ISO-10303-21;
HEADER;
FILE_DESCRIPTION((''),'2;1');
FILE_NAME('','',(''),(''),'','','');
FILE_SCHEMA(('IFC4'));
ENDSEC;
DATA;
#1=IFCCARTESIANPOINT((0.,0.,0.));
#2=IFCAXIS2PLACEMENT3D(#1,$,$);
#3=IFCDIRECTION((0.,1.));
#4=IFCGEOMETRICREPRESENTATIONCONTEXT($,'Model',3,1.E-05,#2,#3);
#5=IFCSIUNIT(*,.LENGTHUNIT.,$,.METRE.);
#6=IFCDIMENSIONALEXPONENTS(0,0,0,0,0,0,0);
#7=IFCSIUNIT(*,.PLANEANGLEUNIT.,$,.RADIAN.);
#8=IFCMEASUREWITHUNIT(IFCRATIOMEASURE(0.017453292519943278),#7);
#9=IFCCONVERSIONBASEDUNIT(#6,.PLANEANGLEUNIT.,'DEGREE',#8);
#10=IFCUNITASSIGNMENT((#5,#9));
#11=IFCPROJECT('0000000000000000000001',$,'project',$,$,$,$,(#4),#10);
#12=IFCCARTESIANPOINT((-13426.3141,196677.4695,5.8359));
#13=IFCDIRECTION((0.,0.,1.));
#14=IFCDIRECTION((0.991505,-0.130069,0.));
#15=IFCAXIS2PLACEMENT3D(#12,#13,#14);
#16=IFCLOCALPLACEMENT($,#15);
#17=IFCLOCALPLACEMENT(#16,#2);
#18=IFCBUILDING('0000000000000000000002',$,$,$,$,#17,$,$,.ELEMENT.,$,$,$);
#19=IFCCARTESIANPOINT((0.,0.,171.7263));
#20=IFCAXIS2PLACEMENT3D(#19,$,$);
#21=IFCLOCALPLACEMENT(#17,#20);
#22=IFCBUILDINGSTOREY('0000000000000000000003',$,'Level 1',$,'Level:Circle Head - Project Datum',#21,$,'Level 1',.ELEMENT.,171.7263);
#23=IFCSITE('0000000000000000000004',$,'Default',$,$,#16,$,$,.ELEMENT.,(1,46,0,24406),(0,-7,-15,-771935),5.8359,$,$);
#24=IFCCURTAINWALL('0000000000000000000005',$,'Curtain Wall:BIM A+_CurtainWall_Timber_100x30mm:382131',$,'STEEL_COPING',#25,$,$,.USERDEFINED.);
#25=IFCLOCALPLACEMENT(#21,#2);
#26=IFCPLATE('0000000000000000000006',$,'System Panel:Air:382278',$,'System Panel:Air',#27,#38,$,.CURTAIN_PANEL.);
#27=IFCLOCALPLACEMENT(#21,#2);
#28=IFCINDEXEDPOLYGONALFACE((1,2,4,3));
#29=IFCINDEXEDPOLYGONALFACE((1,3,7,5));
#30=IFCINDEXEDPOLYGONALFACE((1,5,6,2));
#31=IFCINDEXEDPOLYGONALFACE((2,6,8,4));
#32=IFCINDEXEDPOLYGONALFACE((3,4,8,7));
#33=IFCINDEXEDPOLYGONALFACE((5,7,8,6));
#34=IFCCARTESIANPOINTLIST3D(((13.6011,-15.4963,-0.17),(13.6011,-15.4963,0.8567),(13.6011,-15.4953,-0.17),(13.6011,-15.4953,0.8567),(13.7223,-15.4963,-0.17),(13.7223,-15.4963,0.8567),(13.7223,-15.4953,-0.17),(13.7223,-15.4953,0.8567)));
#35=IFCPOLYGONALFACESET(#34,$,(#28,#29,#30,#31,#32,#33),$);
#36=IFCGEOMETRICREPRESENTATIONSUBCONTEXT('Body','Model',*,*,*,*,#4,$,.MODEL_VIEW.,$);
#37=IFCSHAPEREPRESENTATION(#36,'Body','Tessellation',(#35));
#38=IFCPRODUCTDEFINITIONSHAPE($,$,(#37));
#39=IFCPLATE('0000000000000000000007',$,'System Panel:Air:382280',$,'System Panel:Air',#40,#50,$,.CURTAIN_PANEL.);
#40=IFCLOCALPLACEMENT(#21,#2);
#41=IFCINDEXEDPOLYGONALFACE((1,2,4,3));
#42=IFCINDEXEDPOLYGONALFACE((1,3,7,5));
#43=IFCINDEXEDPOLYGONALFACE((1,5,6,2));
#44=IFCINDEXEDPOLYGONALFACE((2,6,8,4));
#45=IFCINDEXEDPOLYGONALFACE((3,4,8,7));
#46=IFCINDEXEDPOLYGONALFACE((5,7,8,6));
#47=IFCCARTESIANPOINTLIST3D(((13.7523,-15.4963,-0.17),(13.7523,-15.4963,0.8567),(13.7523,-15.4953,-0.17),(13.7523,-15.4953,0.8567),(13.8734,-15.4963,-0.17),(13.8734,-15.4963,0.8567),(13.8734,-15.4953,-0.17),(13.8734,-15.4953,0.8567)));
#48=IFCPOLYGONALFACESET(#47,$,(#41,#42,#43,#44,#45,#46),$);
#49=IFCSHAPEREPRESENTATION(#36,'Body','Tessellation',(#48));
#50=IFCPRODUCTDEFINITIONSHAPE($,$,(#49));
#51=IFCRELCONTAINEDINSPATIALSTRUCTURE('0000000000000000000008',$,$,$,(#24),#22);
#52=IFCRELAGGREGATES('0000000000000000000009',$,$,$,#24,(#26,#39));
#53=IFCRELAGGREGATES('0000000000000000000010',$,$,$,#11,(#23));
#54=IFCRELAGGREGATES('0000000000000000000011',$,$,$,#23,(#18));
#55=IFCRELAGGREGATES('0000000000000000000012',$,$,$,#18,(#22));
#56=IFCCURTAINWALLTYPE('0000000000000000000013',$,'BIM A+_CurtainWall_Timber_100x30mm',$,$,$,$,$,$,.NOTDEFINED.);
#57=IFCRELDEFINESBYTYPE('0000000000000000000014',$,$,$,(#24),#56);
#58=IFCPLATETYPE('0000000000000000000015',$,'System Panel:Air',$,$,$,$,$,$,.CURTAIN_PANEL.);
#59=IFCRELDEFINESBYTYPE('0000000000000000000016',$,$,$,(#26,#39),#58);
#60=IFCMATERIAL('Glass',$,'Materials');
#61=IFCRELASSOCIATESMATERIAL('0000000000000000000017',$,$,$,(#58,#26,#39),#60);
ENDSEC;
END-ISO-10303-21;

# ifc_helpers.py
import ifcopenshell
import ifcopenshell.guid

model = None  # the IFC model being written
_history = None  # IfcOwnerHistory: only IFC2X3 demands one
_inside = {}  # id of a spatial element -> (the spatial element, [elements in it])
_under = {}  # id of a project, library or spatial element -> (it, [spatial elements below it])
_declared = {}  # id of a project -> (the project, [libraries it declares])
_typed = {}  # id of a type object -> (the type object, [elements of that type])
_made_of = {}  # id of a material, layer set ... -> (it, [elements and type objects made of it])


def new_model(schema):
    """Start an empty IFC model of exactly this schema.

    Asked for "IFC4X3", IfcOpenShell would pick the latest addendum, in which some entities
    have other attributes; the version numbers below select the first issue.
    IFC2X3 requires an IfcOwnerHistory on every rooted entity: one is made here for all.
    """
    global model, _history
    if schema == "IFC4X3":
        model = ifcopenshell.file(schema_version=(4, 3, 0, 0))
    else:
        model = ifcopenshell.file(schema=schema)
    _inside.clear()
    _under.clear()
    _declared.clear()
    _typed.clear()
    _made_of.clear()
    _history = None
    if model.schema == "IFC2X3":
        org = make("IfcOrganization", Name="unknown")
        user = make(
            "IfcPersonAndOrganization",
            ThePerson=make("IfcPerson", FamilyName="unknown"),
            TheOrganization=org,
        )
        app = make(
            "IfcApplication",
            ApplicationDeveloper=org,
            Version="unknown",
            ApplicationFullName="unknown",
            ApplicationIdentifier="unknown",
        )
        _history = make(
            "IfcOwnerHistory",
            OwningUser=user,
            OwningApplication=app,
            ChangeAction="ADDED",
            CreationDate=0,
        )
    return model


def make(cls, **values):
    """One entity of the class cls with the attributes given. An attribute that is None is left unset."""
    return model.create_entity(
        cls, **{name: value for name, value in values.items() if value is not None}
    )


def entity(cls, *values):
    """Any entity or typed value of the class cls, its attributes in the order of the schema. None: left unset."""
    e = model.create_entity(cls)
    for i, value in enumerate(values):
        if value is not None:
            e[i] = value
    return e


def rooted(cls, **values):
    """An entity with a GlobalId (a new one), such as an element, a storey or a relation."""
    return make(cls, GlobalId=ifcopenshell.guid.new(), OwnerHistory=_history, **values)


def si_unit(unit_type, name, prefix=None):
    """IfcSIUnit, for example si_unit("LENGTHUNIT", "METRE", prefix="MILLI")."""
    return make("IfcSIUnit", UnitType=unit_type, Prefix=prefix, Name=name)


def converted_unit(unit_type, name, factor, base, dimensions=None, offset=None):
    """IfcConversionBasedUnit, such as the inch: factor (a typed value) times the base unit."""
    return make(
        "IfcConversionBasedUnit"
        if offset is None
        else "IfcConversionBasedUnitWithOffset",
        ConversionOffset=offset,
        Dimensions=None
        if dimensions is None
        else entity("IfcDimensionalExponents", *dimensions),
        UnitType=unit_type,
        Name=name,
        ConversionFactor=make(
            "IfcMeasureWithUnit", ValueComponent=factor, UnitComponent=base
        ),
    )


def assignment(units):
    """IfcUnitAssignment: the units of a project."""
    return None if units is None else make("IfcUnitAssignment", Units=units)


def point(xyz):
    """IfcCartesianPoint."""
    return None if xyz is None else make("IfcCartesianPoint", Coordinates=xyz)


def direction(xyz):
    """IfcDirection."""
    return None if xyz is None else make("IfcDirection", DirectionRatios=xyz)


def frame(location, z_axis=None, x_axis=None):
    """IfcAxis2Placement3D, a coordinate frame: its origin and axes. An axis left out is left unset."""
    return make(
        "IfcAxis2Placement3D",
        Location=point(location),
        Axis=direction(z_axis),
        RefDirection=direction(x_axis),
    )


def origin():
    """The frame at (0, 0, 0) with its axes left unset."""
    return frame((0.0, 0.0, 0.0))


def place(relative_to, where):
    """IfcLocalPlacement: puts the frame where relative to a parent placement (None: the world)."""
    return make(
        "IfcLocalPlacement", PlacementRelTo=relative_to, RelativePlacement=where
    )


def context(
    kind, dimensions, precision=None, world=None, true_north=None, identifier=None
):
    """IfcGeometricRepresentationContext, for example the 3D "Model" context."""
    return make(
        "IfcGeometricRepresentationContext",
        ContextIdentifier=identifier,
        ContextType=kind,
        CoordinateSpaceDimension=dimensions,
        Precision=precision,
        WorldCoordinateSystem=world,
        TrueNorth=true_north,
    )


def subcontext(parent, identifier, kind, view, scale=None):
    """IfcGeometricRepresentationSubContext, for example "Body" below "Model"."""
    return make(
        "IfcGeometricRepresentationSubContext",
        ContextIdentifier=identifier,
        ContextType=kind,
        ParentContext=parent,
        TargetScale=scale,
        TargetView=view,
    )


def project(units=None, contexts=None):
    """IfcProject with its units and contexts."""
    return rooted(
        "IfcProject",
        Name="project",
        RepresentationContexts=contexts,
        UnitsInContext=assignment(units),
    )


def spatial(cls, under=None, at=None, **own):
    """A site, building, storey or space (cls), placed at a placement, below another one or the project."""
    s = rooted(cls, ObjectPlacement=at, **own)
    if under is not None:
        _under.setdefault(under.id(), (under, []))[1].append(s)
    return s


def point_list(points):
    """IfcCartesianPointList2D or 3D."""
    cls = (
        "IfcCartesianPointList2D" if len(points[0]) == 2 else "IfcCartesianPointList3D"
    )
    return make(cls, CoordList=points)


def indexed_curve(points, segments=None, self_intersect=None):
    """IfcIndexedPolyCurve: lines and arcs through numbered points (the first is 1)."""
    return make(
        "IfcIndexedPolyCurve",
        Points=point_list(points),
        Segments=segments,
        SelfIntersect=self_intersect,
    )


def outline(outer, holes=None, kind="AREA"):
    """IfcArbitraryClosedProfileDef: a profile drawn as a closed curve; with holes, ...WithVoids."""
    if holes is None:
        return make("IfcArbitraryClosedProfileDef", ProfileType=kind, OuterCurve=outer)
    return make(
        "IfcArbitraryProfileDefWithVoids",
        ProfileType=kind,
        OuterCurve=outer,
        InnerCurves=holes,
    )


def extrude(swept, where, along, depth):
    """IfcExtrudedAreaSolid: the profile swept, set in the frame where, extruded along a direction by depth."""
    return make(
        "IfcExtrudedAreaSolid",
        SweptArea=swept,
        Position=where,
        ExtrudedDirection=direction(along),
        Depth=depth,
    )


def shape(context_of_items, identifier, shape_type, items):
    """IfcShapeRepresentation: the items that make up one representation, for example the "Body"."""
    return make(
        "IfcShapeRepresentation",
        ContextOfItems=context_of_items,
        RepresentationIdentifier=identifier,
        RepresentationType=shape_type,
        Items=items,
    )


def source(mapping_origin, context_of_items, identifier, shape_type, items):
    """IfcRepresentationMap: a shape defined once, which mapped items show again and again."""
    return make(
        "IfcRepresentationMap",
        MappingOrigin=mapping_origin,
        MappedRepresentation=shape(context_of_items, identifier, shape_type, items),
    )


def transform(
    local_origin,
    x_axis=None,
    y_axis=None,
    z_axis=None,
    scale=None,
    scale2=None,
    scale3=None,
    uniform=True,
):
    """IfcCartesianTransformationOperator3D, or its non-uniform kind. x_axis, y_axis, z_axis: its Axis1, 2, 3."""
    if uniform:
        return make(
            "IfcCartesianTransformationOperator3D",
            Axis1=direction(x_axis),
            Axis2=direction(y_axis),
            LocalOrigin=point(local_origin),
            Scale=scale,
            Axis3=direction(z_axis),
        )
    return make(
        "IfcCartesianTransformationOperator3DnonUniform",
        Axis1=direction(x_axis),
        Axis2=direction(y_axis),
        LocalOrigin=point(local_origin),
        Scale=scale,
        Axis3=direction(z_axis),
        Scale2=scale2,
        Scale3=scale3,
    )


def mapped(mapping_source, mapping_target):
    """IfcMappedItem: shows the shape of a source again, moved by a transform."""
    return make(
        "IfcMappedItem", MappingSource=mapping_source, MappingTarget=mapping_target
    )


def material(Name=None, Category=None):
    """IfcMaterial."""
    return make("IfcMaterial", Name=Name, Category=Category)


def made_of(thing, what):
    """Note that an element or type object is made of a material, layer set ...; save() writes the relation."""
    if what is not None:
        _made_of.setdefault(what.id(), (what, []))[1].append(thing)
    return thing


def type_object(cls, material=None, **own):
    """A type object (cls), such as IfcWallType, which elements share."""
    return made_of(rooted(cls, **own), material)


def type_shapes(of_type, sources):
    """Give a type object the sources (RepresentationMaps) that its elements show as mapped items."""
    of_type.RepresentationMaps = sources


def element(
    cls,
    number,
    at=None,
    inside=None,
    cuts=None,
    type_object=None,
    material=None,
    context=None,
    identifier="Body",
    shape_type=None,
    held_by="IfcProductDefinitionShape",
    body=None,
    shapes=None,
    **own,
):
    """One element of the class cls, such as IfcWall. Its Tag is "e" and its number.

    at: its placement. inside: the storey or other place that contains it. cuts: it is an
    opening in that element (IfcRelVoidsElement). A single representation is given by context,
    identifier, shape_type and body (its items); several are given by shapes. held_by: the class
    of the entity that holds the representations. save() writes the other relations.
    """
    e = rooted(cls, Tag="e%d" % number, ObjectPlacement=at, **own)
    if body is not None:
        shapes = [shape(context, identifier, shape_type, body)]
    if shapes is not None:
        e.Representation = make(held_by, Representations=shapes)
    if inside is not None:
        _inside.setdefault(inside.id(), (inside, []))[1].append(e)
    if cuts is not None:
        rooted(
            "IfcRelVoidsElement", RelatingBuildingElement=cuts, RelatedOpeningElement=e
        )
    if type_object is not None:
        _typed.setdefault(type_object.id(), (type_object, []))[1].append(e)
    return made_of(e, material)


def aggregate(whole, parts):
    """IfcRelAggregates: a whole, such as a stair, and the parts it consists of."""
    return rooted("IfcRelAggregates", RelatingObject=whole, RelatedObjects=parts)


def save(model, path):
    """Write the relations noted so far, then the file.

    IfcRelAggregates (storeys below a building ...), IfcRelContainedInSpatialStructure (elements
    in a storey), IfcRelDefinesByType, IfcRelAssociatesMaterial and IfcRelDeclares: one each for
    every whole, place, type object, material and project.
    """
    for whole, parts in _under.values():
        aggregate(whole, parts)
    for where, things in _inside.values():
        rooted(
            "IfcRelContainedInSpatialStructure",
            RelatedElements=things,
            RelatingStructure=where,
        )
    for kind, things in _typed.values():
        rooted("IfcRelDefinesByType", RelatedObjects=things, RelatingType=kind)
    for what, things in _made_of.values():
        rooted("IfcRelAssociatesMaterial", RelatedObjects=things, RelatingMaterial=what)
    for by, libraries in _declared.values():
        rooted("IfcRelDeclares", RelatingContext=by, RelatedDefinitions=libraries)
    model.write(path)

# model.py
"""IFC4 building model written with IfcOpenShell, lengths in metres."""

from ifc_helpers import new_model, entity, si_unit, converted_unit, direction, frame, origin, place, context, subcontext, project, spatial, indexed_curve, outline, extrude, source, transform, mapped, material, type_object, type_shapes, element, aggregate, save


model = new_model("IFC4")

# Units and contexts
model_context = context("Model", 3, precision=1e-05, world=origin(), true_north=direction((0.0, 1.0)))
body_context = subcontext(model_context, "Body", "Model", "MODEL_VIEW")
ifc_project = project(units=[si_unit("LENGTHUNIT", "METRE"), converted_unit("PLANEANGLEUNIT", "DEGREE", entity("IfcRatioMeasure", 0.017453292519943278), si_unit("PLANEANGLEUNIT", "RADIAN"), dimensions=[0, 0, 0, 0, 0, 0, 0])], contexts=[model_context])

# Site, building, storey
site_placement = place(None, frame((-13426.3141, 196677.4695, 5.8359), z_axis=(0.0, 0.0, 1.0), x_axis=(0.991505, -0.130069, 0.0)))
site = spatial("IfcSite", under=ifc_project, at=site_placement, Name="Default", CompositionType="ELEMENT", RefLatitude=(1, 46, 0, 24406), RefLongitude=(0, -7, -15, -771935), RefElevation=5.8359)
building_placement = place(site_placement, origin())
building = spatial("IfcBuilding", under=site, at=building_placement, CompositionType="ELEMENT")
storey_placement = place(building_placement, frame((0.0, 0.0, 171.7263)))
storey = spatial("IfcBuildingStorey", under=building, at=storey_placement, Name="Level 1", ObjectType="Level:Circle Head - Project Datum", LongName="Level 1", CompositionType="ELEMENT", Elevation=171.7263)

# Curtain wall
curtain_wall_type_1 = type_object("IfcCurtainWallType", Name="BIM A+_CurtainWall_Timber_100x30mm", PredefinedType="NOTDEFINED")
curtain_wall_1_placement = place(storey_placement, frame((0.0, 0.0, -171.7263)))
curtain_wall_1 = element("IfcCurtainWall", 1, at=curtain_wall_1_placement, inside=storey, type_object=curtain_wall_type_1, Name="Curtain Wall:BIM A+_CurtainWall_Timber_100x30mm:382131", ObjectType="STEEL_COPING", PredefinedType="USERDEFINED")

# Plates
ifc_material_1 = material(Name="Glass", Category="Materials")
plate_type_1 = type_object("IfcPlateType", Name="System Panel:Air", PredefinedType="CURTAIN_PANEL", material=ifc_material_1)
shared_shape_1 = source(origin(), body_context, "Body", "SweptSolid", [
    extrude(outline(indexed_curve([(-0.0005, -0.0606), (0.0005, -0.0606), (0.0005, 0.0606), (-0.0005, 0.0606), (-0.0005, -0.0606)], self_intersect=False)), frame((0.0, 0.0, 0.0), z_axis=(0.0, 0.0, 1.0), x_axis=(0.0, 1.0, 0.0)), (0.0, 0.0, 1.0), 1.0267),
])
type_shapes(plate_type_1, [shared_shape_1])
plate_1_placement = place(curtain_wall_1_placement, frame((13.6617, -15.4958, 171.5563)))
plate_1 = element("IfcPlate", 2, at=plate_1_placement, type_object=plate_type_1, material=ifc_material_1, Name="System Panel:Air:382278", ObjectType="System Panel:Air", PredefinedType="CURTAIN_PANEL", context=body_context, shape_type="MappedRepresentation", body=[
    mapped(shared_shape_1, transform((0.0, 0.0, 0.0), scale=1.0)),
])
plate_2_placement = place(curtain_wall_1_placement, frame((13.8129, -15.4958, 171.5563)))
plate_2 = element("IfcPlate", 3, at=plate_2_placement, type_object=plate_type_1, material=ifc_material_1, Name="System Panel:Air:382280", ObjectType="System Panel:Air", PredefinedType="CURTAIN_PANEL", context=body_context, shape_type="MappedRepresentation", body=[
    mapped(shared_shape_1, transform((0.0, 0.0, 0.0), scale=1.0)),
])
aggregate(curtain_wall_1, [plate_1, plate_2])

save(model, "model.ifc")
